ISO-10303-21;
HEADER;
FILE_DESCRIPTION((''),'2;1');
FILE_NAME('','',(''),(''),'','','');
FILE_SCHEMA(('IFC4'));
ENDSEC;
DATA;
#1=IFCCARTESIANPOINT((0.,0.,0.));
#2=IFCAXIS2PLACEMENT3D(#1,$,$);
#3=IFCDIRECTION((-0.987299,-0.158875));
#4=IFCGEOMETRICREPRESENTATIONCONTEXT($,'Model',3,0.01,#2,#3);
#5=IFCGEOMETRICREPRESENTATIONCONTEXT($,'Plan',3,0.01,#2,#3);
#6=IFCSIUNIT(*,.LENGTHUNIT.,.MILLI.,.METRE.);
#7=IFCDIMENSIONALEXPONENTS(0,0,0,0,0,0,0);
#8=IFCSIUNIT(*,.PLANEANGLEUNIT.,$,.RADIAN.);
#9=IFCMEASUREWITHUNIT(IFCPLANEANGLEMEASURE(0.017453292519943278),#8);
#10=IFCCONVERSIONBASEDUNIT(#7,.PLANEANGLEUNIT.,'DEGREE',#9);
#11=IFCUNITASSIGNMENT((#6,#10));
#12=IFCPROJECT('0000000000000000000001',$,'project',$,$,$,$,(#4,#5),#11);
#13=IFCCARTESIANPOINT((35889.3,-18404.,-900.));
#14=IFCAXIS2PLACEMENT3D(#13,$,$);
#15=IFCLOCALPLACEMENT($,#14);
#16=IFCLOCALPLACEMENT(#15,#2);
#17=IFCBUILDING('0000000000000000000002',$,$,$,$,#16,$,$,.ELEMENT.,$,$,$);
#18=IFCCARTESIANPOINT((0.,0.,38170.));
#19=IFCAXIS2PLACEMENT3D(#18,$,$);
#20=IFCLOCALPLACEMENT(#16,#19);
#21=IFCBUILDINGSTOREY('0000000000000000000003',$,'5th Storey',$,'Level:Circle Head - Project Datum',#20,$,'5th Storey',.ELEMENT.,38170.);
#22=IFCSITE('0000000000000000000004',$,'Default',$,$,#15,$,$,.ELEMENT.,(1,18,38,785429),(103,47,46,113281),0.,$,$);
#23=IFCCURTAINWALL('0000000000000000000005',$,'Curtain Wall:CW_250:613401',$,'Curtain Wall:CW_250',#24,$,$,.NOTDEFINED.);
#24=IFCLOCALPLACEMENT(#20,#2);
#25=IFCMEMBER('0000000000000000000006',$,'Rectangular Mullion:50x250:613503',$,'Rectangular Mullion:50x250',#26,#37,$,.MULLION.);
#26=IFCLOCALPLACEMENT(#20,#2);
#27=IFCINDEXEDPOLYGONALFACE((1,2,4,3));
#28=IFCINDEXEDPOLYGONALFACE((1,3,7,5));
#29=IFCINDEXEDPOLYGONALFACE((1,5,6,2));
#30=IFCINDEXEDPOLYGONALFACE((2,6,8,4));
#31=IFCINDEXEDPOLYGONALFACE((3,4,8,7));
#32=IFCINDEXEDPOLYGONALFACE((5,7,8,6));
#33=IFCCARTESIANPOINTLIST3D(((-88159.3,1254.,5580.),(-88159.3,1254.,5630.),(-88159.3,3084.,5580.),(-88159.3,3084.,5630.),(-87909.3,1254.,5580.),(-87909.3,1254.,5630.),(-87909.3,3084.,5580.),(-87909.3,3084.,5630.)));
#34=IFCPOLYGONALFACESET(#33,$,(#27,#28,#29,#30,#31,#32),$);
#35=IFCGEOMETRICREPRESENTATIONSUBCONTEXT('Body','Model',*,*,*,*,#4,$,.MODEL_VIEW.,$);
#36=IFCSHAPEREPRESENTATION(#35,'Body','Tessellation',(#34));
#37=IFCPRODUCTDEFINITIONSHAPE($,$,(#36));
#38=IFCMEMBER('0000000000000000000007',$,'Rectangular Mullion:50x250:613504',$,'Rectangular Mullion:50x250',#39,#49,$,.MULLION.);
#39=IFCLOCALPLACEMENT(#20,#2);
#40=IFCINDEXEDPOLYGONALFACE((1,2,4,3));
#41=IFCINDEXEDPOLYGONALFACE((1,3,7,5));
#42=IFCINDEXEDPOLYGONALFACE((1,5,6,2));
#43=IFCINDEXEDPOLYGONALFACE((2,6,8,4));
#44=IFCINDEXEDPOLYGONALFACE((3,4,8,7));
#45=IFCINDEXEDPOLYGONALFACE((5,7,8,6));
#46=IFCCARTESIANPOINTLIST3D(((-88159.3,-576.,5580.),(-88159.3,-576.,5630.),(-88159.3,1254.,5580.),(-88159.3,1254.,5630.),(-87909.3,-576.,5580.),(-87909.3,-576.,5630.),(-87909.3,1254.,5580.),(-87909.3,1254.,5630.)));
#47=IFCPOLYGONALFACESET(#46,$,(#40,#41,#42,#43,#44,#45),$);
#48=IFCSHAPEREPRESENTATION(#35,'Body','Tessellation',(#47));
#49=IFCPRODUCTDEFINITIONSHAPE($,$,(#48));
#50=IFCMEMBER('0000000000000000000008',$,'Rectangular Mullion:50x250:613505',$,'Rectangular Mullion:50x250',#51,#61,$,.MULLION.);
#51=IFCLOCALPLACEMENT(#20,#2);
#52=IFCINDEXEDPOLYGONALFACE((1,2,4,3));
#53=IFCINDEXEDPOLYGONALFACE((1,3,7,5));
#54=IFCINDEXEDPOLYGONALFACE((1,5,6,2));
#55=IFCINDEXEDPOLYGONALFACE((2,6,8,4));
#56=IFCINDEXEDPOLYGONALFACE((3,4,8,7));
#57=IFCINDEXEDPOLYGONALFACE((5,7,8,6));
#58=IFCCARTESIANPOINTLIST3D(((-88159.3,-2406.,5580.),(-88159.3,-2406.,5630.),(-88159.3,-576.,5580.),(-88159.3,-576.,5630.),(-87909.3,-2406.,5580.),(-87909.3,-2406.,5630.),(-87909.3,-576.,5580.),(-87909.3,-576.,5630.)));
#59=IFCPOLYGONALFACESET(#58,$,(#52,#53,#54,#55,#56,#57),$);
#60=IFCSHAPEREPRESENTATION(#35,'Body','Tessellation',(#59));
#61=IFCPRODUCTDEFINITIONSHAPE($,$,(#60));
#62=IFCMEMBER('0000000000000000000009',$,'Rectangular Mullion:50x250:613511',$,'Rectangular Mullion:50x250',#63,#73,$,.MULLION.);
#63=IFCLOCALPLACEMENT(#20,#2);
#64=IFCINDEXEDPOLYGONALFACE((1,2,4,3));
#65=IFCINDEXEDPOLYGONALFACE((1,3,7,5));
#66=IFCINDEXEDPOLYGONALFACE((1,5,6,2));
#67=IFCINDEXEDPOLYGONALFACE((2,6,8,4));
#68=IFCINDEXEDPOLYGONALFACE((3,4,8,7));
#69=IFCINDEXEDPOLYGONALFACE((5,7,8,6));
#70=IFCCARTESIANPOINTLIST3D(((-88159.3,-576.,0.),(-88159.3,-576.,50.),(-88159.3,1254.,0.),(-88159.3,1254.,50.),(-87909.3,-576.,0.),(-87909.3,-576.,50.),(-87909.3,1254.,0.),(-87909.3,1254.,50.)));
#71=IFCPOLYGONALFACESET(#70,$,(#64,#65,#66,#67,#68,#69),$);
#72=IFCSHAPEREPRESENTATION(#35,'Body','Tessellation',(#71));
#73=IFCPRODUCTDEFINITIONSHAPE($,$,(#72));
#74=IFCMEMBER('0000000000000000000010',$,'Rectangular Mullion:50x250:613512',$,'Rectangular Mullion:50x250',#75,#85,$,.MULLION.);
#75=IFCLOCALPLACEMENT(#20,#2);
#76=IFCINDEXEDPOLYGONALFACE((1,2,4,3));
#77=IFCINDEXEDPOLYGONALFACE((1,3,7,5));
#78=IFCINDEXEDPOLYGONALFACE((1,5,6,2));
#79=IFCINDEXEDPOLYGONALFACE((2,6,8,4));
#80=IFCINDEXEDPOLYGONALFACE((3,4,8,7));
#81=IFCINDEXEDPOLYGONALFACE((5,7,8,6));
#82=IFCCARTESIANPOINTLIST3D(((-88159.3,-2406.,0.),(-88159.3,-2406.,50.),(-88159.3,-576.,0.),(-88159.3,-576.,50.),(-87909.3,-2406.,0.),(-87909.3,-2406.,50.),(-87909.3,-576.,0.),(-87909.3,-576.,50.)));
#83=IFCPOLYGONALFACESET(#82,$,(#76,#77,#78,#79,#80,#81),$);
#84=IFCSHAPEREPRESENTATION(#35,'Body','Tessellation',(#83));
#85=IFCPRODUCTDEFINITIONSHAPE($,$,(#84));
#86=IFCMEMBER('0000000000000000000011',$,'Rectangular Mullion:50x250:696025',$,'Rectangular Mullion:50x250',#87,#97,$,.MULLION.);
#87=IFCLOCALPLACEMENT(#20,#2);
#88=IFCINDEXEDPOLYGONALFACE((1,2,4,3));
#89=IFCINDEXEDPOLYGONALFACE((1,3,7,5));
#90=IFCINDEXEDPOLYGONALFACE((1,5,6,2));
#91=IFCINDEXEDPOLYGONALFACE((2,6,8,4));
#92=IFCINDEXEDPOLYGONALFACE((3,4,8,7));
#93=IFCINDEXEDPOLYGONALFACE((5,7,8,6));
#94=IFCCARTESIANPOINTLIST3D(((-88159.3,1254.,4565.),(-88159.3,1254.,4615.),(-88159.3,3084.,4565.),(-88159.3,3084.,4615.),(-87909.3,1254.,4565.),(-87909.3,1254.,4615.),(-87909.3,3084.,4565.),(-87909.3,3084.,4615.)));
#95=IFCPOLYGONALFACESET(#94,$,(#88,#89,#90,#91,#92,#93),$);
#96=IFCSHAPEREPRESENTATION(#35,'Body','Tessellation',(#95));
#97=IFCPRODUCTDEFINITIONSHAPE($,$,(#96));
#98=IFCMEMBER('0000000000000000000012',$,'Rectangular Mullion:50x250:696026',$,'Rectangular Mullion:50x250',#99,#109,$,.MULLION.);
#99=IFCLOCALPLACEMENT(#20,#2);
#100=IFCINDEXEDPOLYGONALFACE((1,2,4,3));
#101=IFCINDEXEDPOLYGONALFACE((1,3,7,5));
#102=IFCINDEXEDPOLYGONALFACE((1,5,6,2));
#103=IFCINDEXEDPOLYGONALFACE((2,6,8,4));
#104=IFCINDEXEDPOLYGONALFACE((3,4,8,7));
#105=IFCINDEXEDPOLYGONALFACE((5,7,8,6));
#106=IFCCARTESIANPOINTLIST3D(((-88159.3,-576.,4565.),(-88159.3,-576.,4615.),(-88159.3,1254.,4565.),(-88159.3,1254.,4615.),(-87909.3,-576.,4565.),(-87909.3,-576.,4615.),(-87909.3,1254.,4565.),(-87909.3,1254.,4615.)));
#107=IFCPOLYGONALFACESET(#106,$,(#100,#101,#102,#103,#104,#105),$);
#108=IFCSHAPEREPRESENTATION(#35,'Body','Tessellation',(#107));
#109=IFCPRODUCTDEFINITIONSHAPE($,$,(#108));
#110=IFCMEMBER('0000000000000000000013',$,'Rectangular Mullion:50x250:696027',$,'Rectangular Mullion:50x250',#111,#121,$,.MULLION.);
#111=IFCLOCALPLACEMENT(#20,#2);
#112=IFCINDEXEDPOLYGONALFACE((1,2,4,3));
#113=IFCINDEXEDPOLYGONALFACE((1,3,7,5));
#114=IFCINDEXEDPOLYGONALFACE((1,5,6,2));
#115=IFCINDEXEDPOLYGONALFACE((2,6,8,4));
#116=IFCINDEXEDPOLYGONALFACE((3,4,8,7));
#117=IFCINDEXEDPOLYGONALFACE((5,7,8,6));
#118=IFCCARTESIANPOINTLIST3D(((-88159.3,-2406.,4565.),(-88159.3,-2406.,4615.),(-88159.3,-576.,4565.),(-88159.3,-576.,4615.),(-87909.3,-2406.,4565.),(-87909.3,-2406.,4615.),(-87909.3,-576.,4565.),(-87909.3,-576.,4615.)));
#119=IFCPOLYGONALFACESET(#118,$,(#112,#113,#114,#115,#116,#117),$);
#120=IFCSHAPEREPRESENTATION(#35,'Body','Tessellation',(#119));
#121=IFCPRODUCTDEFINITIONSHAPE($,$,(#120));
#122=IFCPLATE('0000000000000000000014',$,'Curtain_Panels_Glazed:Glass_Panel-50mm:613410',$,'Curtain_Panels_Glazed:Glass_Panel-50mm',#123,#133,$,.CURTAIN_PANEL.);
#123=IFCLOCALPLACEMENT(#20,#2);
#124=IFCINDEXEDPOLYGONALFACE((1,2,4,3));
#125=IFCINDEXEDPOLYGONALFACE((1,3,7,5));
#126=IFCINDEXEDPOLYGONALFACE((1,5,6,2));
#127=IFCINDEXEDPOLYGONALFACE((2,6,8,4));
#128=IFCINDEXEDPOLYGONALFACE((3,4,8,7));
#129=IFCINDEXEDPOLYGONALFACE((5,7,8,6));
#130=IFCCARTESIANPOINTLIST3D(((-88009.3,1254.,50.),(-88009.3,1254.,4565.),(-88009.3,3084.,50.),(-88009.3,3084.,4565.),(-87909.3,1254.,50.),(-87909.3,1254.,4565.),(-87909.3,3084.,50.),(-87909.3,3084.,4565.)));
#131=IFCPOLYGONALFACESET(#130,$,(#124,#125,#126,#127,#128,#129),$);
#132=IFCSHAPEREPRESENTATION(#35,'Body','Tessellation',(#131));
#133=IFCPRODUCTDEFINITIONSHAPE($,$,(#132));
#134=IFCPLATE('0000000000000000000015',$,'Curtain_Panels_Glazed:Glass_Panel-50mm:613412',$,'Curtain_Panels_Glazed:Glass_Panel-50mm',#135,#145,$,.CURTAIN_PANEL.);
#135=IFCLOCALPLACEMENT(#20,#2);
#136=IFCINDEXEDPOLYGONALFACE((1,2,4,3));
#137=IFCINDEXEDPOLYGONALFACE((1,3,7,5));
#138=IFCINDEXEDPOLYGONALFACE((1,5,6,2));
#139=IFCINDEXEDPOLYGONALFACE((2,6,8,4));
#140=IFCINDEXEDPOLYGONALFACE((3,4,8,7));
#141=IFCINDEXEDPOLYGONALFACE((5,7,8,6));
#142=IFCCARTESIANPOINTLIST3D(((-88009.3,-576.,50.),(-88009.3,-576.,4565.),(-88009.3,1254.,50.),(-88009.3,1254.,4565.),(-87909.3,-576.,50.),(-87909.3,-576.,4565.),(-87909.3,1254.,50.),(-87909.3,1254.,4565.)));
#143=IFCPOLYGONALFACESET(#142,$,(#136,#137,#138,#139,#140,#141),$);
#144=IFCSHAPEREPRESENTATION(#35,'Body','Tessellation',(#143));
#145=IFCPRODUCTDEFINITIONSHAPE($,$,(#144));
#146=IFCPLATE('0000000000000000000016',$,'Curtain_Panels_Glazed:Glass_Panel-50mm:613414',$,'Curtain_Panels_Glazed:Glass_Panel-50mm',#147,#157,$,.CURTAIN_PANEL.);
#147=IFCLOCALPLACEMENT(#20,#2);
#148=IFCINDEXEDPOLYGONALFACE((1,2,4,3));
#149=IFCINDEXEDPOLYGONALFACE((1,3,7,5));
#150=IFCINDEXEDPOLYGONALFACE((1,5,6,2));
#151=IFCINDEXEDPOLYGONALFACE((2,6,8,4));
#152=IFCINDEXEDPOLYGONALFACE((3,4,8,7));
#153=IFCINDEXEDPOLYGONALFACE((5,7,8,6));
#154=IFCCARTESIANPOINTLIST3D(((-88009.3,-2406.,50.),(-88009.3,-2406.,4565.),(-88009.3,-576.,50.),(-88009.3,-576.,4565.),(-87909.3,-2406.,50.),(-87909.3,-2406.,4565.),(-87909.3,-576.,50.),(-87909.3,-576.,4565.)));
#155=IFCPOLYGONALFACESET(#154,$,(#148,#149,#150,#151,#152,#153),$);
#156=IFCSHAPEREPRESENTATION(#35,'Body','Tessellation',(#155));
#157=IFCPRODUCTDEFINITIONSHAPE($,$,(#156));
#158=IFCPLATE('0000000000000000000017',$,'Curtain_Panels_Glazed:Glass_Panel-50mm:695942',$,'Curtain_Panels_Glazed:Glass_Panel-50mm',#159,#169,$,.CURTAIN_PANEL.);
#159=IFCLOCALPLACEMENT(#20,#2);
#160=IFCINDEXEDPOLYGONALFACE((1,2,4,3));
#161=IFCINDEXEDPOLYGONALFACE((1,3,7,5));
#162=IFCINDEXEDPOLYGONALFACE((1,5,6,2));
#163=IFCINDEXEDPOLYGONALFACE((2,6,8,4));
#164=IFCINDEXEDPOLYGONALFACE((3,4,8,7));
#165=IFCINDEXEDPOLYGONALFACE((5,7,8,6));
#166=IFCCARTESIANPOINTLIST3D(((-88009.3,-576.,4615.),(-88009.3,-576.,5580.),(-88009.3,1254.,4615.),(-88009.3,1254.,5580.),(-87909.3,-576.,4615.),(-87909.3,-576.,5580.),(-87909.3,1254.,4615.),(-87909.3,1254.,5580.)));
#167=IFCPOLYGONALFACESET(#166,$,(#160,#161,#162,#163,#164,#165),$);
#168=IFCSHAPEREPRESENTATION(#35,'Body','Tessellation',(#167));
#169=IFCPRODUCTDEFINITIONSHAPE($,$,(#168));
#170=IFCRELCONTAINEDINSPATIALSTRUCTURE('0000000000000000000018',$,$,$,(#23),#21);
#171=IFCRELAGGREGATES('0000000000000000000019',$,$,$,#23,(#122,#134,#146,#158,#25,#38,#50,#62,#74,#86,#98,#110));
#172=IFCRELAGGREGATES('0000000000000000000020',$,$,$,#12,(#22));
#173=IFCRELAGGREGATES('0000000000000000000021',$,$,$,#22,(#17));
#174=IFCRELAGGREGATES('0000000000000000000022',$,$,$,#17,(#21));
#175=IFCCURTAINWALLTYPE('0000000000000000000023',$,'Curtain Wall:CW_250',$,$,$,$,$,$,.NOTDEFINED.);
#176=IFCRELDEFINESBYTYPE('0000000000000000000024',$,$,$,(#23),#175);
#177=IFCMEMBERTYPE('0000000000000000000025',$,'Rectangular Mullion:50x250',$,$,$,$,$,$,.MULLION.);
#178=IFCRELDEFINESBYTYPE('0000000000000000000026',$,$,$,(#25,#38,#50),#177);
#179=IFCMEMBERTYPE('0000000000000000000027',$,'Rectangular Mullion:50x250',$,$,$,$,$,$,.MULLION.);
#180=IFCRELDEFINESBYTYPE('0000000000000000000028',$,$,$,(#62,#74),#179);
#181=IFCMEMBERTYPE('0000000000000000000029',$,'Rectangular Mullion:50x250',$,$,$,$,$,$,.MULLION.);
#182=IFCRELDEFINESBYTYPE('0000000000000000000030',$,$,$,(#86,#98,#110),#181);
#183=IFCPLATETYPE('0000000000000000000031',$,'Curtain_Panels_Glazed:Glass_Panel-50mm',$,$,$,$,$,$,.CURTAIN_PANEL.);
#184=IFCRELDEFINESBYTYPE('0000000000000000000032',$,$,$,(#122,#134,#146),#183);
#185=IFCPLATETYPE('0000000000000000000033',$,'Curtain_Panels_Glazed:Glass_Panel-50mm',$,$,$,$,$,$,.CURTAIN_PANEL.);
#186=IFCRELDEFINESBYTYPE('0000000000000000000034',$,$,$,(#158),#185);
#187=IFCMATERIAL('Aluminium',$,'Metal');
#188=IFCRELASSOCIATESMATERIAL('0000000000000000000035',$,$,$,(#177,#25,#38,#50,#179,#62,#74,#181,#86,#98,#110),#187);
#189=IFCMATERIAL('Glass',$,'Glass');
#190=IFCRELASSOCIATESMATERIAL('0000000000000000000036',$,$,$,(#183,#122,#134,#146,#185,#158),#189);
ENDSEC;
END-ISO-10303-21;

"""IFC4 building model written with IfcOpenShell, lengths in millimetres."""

from ifc_helpers import new_model, entity, si_unit, converted_unit, direction, frame, origin, place, context, subcontext, project, spatial, indexed_curve, outline, extrude, source, transform, mapped, material, type_object, type_shapes, element, aggregate, save


model = new_model("IFC4")

# Units and contexts
model_context = context("Model", 3, precision=0.01, world=origin(), true_north=direction((-0.987299, -0.158875)))
plan_context = context("Plan", 3, precision=0.01, world=origin(), true_north=direction((-0.987299, -0.158875)))
body_context = subcontext(model_context, "Body", "Model", "MODEL_VIEW")
ifc_project = project(units=[si_unit("LENGTHUNIT", "METRE", prefix="MILLI"), converted_unit("PLANEANGLEUNIT", "DEGREE", entity("IfcPlaneAngleMeasure", 0.017453292519943278), si_unit("PLANEANGLEUNIT", "RADIAN"), dimensions=[0, 0, 0, 0, 0, 0, 0])], contexts=[model_context, plan_context])

# Site, building, storey
site_placement = place(None, frame((35889.3, -18404.0, -900.0)))
site = spatial("IfcSite", under=ifc_project, at=site_placement, Name="Default", CompositionType="ELEMENT", RefLatitude=(1, 18, 38, 785429), RefLongitude=(103, 47, 46, 113281), RefElevation=0.0)
building_placement = place(site_placement, origin())
building = spatial("IfcBuilding", under=site, at=building_placement, CompositionType="ELEMENT")
storey_placement = place(building_placement, frame((0.0, 0.0, 38170.0)))
storey = spatial("IfcBuildingStorey", under=building, at=storey_placement, Name="5th Storey", ObjectType="Level:Circle Head - Project Datum", LongName="5th Storey", CompositionType="ELEMENT", Elevation=38170.0)

# Curtain wall, members
curtain_wall_type = type_object("IfcCurtainWallType", Name="Curtain Wall:CW_250", PredefinedType="NOTDEFINED")
curtain_wall_1_placement = place(storey_placement, frame((0.0, 0.0, -38170.0)))
curtain_wall_1 = element("IfcCurtainWall", 1, at=curtain_wall_1_placement, inside=storey, type_object=curtain_wall_type, Name="Curtain Wall:CW_250:613401", ObjectType="Curtain Wall:CW_250", PredefinedType="NOTDEFINED")
ifc_material_1 = material(Name="Aluminium", Category="Metal")
member_type_1 = type_object("IfcMemberType", Name="Rectangular Mullion:50x250", PredefinedType="MULLION", material=ifc_material_1)
shared_shape_1 = source(origin(), body_context, "Body", "SweptSolid", [
    extrude(outline(indexed_curve([(-25.0, -125.0), (25.0, -125.0), (25.0, 125.0), (-25.0, 125.0), (-25.0, -125.0)], self_intersect=False)), frame((-25.0, -125.0, -1830.0), z_axis=(0.0, 0.0, 1.0), x_axis=(-1.0, 0.0, 0.0)), (0.0, 0.0, 1.0), 1830.0),
])
type_shapes(member_type_1, [shared_shape_1])
member_1_placement = place(curtain_wall_1_placement, frame((-88159.3, 1254.0, 43800.0), z_axis=(0.0, -1.0, 0.0), x_axis=(0.0, 0.0, 1.0)))
member_1 = element("IfcMember", 2, at=member_1_placement, type_object=member_type_1, material=ifc_material_1, Name="Rectangular Mullion:50x250:613503", ObjectType="Rectangular Mullion:50x250", PredefinedType="MULLION", context=body_context, shape_type="MappedRepresentation", body=[
    mapped(shared_shape_1, transform((0.0, 0.0, 0.0), scale=1.0)),
])
member_2_placement = place(curtain_wall_1_placement, frame((-88159.3, -576.0, 43800.0), z_axis=(0.0, -1.0, 0.0), x_axis=(0.0, 0.0, 1.0)))
member_2 = element("IfcMember", 3, at=member_2_placement, type_object=member_type_1, material=ifc_material_1, Name="Rectangular Mullion:50x250:613504", ObjectType="Rectangular Mullion:50x250", PredefinedType="MULLION", context=body_context, shape_type="MappedRepresentation", body=[
    mapped(shared_shape_1, transform((0.0, 0.0, 0.0), scale=1.0)),
])
member_3_placement = place(curtain_wall_1_placement, frame((-88159.3, -2406.0, 43800.0), z_axis=(0.0, -1.0, 0.0), x_axis=(0.0, 0.0, 1.0)))
member_3 = element("IfcMember", 4, at=member_3_placement, type_object=member_type_1, material=ifc_material_1, Name="Rectangular Mullion:50x250:613505", ObjectType="Rectangular Mullion:50x250", PredefinedType="MULLION", context=body_context, shape_type="MappedRepresentation", body=[
    mapped(shared_shape_1, transform((0.0, 0.0, 0.0), scale=1.0)),
])
member_type_2 = type_object("IfcMemberType", Name="Rectangular Mullion:50x250", PredefinedType="MULLION", material=ifc_material_1)
shared_shape_2 = source(origin(), body_context, "Body", "SweptSolid", [
    extrude(outline(indexed_curve([(-25.0, -125.0), (25.0, -125.0), (25.0, 125.0), (-25.0, 125.0), (-25.0, -125.0)], self_intersect=False)), frame((-25.0, -125.0, -1830.0), z_axis=(0.0, 0.0, 1.0), x_axis=(-1.0, 0.0, 0.0)), (0.0, 0.0, 1.0), 1830.0),
])
type_shapes(member_type_2, [shared_shape_2])
member_4_placement = place(curtain_wall_1_placement, frame((-88159.3, 1254.0, 38170.0), z_axis=(0.0, 1.0, 0.0), x_axis=(0.0, 0.0, -1.0)))
member_4 = element("IfcMember", 5, at=member_4_placement, type_object=member_type_2, material=ifc_material_1, Name="Rectangular Mullion:50x250:613511", ObjectType="Rectangular Mullion:50x250", PredefinedType="MULLION", context=body_context, shape_type="MappedRepresentation", body=[
    mapped(shared_shape_2, transform((0.0, 0.0, 0.0), scale=1.0)),
])
member_5_placement = place(curtain_wall_1_placement, frame((-88159.3, -576.0, 38170.0), z_axis=(0.0, 1.0, 0.0), x_axis=(0.0, 0.0, -1.0)))
member_5 = element("IfcMember", 6, at=member_5_placement, type_object=member_type_2, material=ifc_material_1, Name="Rectangular Mullion:50x250:613512", ObjectType="Rectangular Mullion:50x250", PredefinedType="MULLION", context=body_context, shape_type="MappedRepresentation", body=[
    mapped(shared_shape_2, transform((0.0, 0.0, 0.0), scale=1.0)),
])

# Members
member_type_3 = type_object("IfcMemberType", Name="Rectangular Mullion:50x250", PredefinedType="MULLION", material=ifc_material_1)
shared_shape_3 = source(origin(), body_context, "Body", "SweptSolid", [
    extrude(outline(indexed_curve([(-25.0, -125.0), (25.0, -125.0), (25.0, 125.0), (-25.0, 125.0), (-25.0, -125.0)], self_intersect=False)), frame((0.0, -125.0, -1830.0), z_axis=(0.0, 0.0, 1.0), x_axis=(-1.0, 0.0, 0.0)), (0.0, 0.0, 1.0), 1830.0),
])
type_shapes(member_type_3, [shared_shape_3])
member_6_placement = place(curtain_wall_1_placement, frame((-88159.3, 1254.0, 42760.0), z_axis=(0.0, -1.0, 0.0), x_axis=(0.0, 0.0, 1.0)))
member_6 = element("IfcMember", 7, at=member_6_placement, type_object=member_type_3, material=ifc_material_1, Name="Rectangular Mullion:50x250:696025", ObjectType="Rectangular Mullion:50x250", PredefinedType="MULLION", context=body_context, shape_type="MappedRepresentation", body=[
    mapped(shared_shape_3, transform((0.0, 0.0, 0.0), scale=1.0)),
])
member_7_placement = place(curtain_wall_1_placement, frame((-88159.3, -576.0, 42760.0), z_axis=(0.0, -1.0, 0.0), x_axis=(0.0, 0.0, 1.0)))
member_7 = element("IfcMember", 8, at=member_7_placement, type_object=member_type_3, material=ifc_material_1, Name="Rectangular Mullion:50x250:696026", ObjectType="Rectangular Mullion:50x250", PredefinedType="MULLION", context=body_context, shape_type="MappedRepresentation", body=[
    mapped(shared_shape_3, transform((0.0, 0.0, 0.0), scale=1.0)),
])
member_8_placement = place(curtain_wall_1_placement, frame((-88159.3, -2406.0, 42760.0), z_axis=(0.0, -1.0, 0.0), x_axis=(0.0, 0.0, 1.0)))
member_8 = element("IfcMember", 9, at=member_8_placement, type_object=member_type_3, material=ifc_material_1, Name="Rectangular Mullion:50x250:696027", ObjectType="Rectangular Mullion:50x250", PredefinedType="MULLION", context=body_context, shape_type="MappedRepresentation", body=[
    mapped(shared_shape_3, transform((0.0, 0.0, 0.0), scale=1.0)),
])

# Plates
ifc_material_2 = material(Name="Glass", Category="Glass")
plate_type_1 = type_object("IfcPlateType", Name="Curtain_Panels_Glazed:Glass_Panel-50mm", PredefinedType="CURTAIN_PANEL", material=ifc_material_2)
shared_shape_4 = source(origin(), body_context, "Body", "SweptSolid", [
    extrude(outline(indexed_curve([(-50.0, -915.0), (50.0, -915.0), (50.0, 915.0), (-50.0, 915.0), (-50.0, -915.0)], self_intersect=False)), frame((0.0, 200.0, 0.0), z_axis=(0.0, 0.0, 1.0), x_axis=(0.0, 1.0, 0.0)), (0.0, 0.0, 1.0), 4515.0),
])
type_shapes(plate_type_1, [shared_shape_4])
plate_1_placement = place(curtain_wall_1_placement, frame((-88159.3, 2169.0, 38220.0), z_axis=(0.0, 0.0, 1.0), x_axis=(0.0, -1.0, 0.0)))
plate_1 = element("IfcPlate", 10, at=plate_1_placement, type_object=plate_type_1, material=ifc_material_2, Name="Curtain_Panels_Glazed:Glass_Panel-50mm:613410", ObjectType="Curtain_Panels_Glazed:Glass_Panel-50mm", PredefinedType="CURTAIN_PANEL", context=body_context, shape_type="MappedRepresentation", body=[
    mapped(shared_shape_4, transform((0.0, 0.0, 0.0), scale=1.0)),
])
plate_2_placement = place(curtain_wall_1_placement, frame((-88159.3, 339.0, 38220.0), z_axis=(0.0, 0.0, 1.0), x_axis=(0.0, -1.0, 0.0)))
plate_2 = element("IfcPlate", 11, at=plate_2_placement, type_object=plate_type_1, material=ifc_material_2, Name="Curtain_Panels_Glazed:Glass_Panel-50mm:613412", ObjectType="Curtain_Panels_Glazed:Glass_Panel-50mm", PredefinedType="CURTAIN_PANEL", context=body_context, shape_type="MappedRepresentation", body=[
    mapped(shared_shape_4, transform((0.0, 0.0, 0.0), scale=1.0)),
])
plate_3_placement = place(curtain_wall_1_placement, frame((-88159.3, -1491.0, 38220.0), z_axis=(0.0, 0.0, 1.0), x_axis=(0.0, -1.0, 0.0)))
plate_3 = element("IfcPlate", 12, at=plate_3_placement, type_object=plate_type_1, material=ifc_material_2, Name="Curtain_Panels_Glazed:Glass_Panel-50mm:613414", ObjectType="Curtain_Panels_Glazed:Glass_Panel-50mm", PredefinedType="CURTAIN_PANEL", context=body_context, shape_type="MappedRepresentation", body=[
    mapped(shared_shape_4, transform((0.0, 0.0, 0.0), scale=1.0)),
])
plate_type_2 = type_object("IfcPlateType", Name="Curtain_Panels_Glazed:Glass_Panel-50mm", PredefinedType="CURTAIN_PANEL", material=ifc_material_2)
shared_shape_5 = source(origin(), body_context, "Body", "SweptSolid", [
    extrude(outline(indexed_curve([(-50.0, -915.0), (50.0, -915.0), (50.0, 915.0), (-50.0, 915.0), (-50.0, -915.0)], self_intersect=False)), frame((0.0, 200.0, 0.0), z_axis=(0.0, 0.0, 1.0), x_axis=(0.0, 1.0, 0.0)), (0.0, 0.0, 1.0), 965.0),
])
type_shapes(plate_type_2, [shared_shape_5])
plate_4_placement = place(curtain_wall_1_placement, frame((-88159.3, 339.0, 42785.0), z_axis=(0.0, 0.0, 1.0), x_axis=(0.0, -1.0, 0.0)))
plate_4 = element("IfcPlate", 13, at=plate_4_placement, type_object=plate_type_2, material=ifc_material_2, Name="Curtain_Panels_Glazed:Glass_Panel-50mm:695942", ObjectType="Curtain_Panels_Glazed:Glass_Panel-50mm", PredefinedType="CURTAIN_PANEL", context=body_context, shape_type="MappedRepresentation", body=[
    mapped(shared_shape_5, transform((0.0, 0.0, 0.0), scale=1.0)),
])
aggregate(curtain_wall_1, [plate_1, plate_2, plate_3, plate_4, member_1, member_2, member_3, member_4, member_5, member_6, member_7, member_8])

save(model, "model.ifc")
